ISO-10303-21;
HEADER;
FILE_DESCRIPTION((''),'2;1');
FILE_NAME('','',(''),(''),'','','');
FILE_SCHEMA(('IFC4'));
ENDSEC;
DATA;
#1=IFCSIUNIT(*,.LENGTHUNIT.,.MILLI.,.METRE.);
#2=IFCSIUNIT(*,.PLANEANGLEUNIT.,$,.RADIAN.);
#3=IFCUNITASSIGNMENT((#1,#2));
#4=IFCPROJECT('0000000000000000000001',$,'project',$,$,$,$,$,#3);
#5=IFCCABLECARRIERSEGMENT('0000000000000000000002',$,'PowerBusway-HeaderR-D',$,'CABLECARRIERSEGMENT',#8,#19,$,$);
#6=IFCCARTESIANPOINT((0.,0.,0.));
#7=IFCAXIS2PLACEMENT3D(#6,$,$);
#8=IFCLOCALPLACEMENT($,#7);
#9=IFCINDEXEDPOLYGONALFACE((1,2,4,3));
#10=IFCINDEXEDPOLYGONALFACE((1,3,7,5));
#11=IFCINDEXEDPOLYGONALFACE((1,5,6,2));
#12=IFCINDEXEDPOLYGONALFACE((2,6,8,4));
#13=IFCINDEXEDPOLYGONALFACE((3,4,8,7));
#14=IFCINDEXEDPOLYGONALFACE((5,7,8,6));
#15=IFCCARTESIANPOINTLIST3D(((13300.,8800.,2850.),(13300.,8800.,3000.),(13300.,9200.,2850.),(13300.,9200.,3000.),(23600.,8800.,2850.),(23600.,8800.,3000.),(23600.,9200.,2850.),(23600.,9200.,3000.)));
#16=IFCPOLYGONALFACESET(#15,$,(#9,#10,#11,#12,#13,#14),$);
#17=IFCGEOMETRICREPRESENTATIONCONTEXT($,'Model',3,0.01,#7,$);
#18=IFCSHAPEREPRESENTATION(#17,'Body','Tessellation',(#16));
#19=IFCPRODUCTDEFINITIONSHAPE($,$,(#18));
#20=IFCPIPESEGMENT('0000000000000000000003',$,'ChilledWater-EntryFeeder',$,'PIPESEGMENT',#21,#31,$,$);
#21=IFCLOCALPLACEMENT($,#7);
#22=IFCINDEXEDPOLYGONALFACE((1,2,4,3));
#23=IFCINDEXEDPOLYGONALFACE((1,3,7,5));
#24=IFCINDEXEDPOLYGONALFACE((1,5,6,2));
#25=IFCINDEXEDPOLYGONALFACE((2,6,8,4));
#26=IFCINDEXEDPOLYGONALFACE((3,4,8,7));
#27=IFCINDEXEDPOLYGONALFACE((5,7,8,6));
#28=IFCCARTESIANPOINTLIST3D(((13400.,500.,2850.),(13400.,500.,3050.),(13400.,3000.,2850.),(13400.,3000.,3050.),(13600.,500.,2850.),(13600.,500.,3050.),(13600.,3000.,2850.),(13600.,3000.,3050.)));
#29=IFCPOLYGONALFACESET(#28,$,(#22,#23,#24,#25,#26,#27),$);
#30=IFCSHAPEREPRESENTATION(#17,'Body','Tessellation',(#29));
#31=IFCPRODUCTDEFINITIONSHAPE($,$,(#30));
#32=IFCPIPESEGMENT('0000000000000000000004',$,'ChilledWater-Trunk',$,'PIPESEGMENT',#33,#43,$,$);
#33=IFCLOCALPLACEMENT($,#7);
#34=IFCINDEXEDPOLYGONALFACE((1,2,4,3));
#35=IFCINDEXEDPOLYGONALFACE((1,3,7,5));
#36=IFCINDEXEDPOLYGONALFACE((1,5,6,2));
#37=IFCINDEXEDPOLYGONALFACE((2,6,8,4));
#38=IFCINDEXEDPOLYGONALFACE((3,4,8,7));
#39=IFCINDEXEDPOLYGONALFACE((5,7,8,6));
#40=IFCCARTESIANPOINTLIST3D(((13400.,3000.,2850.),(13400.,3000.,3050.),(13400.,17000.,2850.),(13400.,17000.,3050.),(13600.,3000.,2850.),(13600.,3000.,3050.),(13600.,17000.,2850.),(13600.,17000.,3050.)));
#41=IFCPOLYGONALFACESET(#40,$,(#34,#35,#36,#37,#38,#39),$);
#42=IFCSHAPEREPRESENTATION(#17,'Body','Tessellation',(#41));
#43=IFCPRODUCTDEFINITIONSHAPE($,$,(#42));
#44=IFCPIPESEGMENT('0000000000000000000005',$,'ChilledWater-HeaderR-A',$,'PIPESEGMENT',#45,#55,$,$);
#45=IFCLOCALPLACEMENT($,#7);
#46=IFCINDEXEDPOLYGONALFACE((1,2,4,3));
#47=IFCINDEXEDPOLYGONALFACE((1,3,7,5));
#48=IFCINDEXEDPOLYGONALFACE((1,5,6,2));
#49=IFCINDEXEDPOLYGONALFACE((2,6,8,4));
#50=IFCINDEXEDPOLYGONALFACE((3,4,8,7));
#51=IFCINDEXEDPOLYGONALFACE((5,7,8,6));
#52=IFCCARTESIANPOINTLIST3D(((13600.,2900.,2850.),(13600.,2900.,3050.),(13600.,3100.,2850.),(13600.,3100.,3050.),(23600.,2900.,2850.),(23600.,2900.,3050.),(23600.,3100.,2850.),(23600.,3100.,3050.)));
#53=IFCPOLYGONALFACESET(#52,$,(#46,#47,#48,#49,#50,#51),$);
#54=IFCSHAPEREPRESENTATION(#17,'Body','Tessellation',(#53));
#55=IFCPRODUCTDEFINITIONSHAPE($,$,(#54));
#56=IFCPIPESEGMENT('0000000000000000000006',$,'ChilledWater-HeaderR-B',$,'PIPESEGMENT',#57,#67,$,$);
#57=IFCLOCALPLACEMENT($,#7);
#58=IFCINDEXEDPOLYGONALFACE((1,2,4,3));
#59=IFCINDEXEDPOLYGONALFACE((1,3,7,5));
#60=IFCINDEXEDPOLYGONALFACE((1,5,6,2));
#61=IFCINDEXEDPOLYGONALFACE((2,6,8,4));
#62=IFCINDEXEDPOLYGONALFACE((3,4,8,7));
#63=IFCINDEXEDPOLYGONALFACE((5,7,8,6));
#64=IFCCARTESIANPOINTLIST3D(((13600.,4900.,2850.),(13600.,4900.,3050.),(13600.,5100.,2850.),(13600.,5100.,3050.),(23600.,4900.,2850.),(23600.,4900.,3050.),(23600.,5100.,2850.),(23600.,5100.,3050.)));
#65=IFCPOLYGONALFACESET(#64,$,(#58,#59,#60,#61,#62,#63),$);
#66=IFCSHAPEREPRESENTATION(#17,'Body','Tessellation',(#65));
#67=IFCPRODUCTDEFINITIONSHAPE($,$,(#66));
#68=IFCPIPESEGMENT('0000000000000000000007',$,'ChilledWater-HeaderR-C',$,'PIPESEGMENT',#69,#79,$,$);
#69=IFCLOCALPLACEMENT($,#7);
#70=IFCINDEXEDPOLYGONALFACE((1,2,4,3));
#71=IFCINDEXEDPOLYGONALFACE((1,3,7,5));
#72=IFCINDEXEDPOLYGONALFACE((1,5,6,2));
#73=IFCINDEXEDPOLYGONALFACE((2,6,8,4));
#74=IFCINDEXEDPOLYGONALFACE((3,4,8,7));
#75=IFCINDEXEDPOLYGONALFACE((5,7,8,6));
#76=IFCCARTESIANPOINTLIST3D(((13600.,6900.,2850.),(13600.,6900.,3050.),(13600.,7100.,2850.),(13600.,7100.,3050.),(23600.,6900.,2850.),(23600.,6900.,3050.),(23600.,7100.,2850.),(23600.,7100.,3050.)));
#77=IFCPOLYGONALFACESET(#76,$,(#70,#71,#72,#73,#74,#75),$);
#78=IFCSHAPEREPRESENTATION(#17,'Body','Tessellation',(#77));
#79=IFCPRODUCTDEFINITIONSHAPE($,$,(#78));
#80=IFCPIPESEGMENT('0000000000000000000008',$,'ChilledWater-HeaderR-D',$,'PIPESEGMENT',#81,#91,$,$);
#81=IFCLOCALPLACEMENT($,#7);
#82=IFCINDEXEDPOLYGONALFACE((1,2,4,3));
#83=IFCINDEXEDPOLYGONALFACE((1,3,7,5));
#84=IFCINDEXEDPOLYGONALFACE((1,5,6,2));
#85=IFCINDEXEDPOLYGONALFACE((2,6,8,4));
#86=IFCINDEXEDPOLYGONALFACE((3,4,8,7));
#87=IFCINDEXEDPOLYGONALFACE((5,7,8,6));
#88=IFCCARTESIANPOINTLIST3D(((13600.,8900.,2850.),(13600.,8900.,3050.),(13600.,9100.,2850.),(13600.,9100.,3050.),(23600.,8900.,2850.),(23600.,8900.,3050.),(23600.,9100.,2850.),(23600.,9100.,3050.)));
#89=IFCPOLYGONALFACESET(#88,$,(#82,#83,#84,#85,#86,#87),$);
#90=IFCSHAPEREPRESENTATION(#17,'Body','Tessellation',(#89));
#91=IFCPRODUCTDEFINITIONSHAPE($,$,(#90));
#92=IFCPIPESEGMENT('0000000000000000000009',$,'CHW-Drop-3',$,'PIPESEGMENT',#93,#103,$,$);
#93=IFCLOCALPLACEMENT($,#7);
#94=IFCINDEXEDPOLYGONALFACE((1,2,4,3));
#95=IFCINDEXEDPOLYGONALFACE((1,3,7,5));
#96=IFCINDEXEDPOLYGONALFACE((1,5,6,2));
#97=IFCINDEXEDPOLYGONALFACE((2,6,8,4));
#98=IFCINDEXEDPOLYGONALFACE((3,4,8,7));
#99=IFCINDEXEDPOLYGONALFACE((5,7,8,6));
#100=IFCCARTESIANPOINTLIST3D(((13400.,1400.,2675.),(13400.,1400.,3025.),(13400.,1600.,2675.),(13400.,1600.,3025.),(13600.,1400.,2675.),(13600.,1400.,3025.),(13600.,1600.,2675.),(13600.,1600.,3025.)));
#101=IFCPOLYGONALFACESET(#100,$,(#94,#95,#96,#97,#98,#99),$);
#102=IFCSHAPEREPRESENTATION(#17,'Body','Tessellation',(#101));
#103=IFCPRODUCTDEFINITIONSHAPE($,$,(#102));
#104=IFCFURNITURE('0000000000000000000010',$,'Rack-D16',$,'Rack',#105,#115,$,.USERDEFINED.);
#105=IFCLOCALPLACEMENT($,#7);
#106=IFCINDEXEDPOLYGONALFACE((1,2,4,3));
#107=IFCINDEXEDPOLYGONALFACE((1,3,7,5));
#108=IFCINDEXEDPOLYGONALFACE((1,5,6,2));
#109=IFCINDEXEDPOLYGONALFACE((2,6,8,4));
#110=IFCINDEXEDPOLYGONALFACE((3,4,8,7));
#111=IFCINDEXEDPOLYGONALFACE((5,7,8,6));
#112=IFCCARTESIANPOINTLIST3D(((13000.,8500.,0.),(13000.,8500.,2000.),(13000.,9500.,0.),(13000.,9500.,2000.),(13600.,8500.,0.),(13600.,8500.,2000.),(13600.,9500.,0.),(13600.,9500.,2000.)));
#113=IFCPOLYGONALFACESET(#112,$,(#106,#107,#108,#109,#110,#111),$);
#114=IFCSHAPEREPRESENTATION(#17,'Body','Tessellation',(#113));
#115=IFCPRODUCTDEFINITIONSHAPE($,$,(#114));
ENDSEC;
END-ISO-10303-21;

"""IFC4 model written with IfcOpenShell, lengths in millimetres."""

from ifc_helpers import new_model, si_unit, frame, origin, place, context, project, polyline, outline, extrude, element, save


model = new_model("IFC4")

# Units and contexts
model_context = context("Model", 3, precision=0.01, world=origin())
ifc_project = project(units=[si_unit("LENGTHUNIT", "METRE", prefix="MILLI"), si_unit("PLANEANGLEUNIT", "RADIAN")])

# Cable carrier segment
for number, where, name in (
    (1, (18450.0, 9000.0, 2850.0), "PowerBusway-HeaderR-D"),
):
    element("IfcCableCarrierSegment", number, at=place(None, frame(where)), Name=name, ObjectType="CABLECARRIERSEGMENT", context=model_context, shape_type="SweptSolid", body=[
        extrude(outline(polyline([(-5150.0, -200.0), (5150.0, -200.0), (5150.0, 200.0), (-5150.0, 200.0), (-5150.0, -200.0)])), origin(), (0.0, 0.0, 1.0), 150.0),
    ])

# Pipe segments
pipe_segment_1_placement = place(None, frame((13500.0, 1750.0, 2850.0)))
element("IfcPipeSegment", 2, at=pipe_segment_1_placement, Name="ChilledWater-EntryFeeder", ObjectType="PIPESEGMENT", context=model_context, shape_type="SweptSolid", body=[
    extrude(outline(polyline([(-100.0, -1250.0), (100.0, -1250.0), (100.0, 1250.0), (-100.0, 1250.0), (-100.0, -1250.0)])), origin(), (0.0, 0.0, 1.0), 200.0),
])
pipe_segment_2_placement = place(None, frame((13500.0, 10000.0, 2850.0)))
element("IfcPipeSegment", 3, at=pipe_segment_2_placement, Name="ChilledWater-Trunk", ObjectType="PIPESEGMENT", context=model_context, shape_type="SweptSolid", body=[
    extrude(outline(polyline([(-100.0, -7000.0), (100.0, -7000.0), (100.0, 7000.0), (-100.0, 7000.0), (-100.0, -7000.0)])), origin(), (0.0, 0.0, 1.0), 200.0),
])
for number, where, name in (
    (4, (18600.0, 3000.0, 2850.0), "ChilledWater-HeaderR-A"),
    (5, (18600.0, 5000.0, 2850.0), "ChilledWater-HeaderR-B"),
    (6, (18600.0, 7000.0, 2850.0), "ChilledWater-HeaderR-C"),
    (7, (18600.0, 9000.0, 2850.0), "ChilledWater-HeaderR-D"),
):
    element("IfcPipeSegment", number, at=place(None, frame(where)), Name=name, ObjectType="PIPESEGMENT", context=model_context, shape_type="SweptSolid", body=[
        extrude(outline(polyline([(-5000.0, -100.0), (5000.0, -100.0), (5000.0, 100.0), (-5000.0, 100.0), (-5000.0, -100.0)])), origin(), (0.0, 0.0, 1.0), 200.0),
    ])
pipe_segment_3_placement = place(None, frame((13500.0, 1500.0, 2675.0)))
element("IfcPipeSegment", 8, at=pipe_segment_3_placement, Name="CHW-Drop-3", ObjectType="PIPESEGMENT", context=model_context, shape_type="SweptSolid", body=[
    extrude(outline(polyline([(-100.0, -100.0), (100.0, -100.0), (100.0, 100.0), (-100.0, 100.0), (-100.0, -100.0)])), origin(), (0.0, 0.0, 1.0), 350.0),
])

# Furniture
furniture_placement = place(None, frame((13300.0, 9000.0, 0.0)))
element("IfcFurniture", 9, at=furniture_placement, Name="Rack-D16", ObjectType="Rack", PredefinedType="USERDEFINED", context=model_context, shape_type="SweptSolid", body=[
    extrude(outline(polyline([(-300.0, -500.0), (300.0, -500.0), (300.0, 500.0), (-300.0, 500.0), (-300.0, -500.0)])), origin(), (0.0, 0.0, 1.0), 2000.0),
])

save(model, "model.ifc")
